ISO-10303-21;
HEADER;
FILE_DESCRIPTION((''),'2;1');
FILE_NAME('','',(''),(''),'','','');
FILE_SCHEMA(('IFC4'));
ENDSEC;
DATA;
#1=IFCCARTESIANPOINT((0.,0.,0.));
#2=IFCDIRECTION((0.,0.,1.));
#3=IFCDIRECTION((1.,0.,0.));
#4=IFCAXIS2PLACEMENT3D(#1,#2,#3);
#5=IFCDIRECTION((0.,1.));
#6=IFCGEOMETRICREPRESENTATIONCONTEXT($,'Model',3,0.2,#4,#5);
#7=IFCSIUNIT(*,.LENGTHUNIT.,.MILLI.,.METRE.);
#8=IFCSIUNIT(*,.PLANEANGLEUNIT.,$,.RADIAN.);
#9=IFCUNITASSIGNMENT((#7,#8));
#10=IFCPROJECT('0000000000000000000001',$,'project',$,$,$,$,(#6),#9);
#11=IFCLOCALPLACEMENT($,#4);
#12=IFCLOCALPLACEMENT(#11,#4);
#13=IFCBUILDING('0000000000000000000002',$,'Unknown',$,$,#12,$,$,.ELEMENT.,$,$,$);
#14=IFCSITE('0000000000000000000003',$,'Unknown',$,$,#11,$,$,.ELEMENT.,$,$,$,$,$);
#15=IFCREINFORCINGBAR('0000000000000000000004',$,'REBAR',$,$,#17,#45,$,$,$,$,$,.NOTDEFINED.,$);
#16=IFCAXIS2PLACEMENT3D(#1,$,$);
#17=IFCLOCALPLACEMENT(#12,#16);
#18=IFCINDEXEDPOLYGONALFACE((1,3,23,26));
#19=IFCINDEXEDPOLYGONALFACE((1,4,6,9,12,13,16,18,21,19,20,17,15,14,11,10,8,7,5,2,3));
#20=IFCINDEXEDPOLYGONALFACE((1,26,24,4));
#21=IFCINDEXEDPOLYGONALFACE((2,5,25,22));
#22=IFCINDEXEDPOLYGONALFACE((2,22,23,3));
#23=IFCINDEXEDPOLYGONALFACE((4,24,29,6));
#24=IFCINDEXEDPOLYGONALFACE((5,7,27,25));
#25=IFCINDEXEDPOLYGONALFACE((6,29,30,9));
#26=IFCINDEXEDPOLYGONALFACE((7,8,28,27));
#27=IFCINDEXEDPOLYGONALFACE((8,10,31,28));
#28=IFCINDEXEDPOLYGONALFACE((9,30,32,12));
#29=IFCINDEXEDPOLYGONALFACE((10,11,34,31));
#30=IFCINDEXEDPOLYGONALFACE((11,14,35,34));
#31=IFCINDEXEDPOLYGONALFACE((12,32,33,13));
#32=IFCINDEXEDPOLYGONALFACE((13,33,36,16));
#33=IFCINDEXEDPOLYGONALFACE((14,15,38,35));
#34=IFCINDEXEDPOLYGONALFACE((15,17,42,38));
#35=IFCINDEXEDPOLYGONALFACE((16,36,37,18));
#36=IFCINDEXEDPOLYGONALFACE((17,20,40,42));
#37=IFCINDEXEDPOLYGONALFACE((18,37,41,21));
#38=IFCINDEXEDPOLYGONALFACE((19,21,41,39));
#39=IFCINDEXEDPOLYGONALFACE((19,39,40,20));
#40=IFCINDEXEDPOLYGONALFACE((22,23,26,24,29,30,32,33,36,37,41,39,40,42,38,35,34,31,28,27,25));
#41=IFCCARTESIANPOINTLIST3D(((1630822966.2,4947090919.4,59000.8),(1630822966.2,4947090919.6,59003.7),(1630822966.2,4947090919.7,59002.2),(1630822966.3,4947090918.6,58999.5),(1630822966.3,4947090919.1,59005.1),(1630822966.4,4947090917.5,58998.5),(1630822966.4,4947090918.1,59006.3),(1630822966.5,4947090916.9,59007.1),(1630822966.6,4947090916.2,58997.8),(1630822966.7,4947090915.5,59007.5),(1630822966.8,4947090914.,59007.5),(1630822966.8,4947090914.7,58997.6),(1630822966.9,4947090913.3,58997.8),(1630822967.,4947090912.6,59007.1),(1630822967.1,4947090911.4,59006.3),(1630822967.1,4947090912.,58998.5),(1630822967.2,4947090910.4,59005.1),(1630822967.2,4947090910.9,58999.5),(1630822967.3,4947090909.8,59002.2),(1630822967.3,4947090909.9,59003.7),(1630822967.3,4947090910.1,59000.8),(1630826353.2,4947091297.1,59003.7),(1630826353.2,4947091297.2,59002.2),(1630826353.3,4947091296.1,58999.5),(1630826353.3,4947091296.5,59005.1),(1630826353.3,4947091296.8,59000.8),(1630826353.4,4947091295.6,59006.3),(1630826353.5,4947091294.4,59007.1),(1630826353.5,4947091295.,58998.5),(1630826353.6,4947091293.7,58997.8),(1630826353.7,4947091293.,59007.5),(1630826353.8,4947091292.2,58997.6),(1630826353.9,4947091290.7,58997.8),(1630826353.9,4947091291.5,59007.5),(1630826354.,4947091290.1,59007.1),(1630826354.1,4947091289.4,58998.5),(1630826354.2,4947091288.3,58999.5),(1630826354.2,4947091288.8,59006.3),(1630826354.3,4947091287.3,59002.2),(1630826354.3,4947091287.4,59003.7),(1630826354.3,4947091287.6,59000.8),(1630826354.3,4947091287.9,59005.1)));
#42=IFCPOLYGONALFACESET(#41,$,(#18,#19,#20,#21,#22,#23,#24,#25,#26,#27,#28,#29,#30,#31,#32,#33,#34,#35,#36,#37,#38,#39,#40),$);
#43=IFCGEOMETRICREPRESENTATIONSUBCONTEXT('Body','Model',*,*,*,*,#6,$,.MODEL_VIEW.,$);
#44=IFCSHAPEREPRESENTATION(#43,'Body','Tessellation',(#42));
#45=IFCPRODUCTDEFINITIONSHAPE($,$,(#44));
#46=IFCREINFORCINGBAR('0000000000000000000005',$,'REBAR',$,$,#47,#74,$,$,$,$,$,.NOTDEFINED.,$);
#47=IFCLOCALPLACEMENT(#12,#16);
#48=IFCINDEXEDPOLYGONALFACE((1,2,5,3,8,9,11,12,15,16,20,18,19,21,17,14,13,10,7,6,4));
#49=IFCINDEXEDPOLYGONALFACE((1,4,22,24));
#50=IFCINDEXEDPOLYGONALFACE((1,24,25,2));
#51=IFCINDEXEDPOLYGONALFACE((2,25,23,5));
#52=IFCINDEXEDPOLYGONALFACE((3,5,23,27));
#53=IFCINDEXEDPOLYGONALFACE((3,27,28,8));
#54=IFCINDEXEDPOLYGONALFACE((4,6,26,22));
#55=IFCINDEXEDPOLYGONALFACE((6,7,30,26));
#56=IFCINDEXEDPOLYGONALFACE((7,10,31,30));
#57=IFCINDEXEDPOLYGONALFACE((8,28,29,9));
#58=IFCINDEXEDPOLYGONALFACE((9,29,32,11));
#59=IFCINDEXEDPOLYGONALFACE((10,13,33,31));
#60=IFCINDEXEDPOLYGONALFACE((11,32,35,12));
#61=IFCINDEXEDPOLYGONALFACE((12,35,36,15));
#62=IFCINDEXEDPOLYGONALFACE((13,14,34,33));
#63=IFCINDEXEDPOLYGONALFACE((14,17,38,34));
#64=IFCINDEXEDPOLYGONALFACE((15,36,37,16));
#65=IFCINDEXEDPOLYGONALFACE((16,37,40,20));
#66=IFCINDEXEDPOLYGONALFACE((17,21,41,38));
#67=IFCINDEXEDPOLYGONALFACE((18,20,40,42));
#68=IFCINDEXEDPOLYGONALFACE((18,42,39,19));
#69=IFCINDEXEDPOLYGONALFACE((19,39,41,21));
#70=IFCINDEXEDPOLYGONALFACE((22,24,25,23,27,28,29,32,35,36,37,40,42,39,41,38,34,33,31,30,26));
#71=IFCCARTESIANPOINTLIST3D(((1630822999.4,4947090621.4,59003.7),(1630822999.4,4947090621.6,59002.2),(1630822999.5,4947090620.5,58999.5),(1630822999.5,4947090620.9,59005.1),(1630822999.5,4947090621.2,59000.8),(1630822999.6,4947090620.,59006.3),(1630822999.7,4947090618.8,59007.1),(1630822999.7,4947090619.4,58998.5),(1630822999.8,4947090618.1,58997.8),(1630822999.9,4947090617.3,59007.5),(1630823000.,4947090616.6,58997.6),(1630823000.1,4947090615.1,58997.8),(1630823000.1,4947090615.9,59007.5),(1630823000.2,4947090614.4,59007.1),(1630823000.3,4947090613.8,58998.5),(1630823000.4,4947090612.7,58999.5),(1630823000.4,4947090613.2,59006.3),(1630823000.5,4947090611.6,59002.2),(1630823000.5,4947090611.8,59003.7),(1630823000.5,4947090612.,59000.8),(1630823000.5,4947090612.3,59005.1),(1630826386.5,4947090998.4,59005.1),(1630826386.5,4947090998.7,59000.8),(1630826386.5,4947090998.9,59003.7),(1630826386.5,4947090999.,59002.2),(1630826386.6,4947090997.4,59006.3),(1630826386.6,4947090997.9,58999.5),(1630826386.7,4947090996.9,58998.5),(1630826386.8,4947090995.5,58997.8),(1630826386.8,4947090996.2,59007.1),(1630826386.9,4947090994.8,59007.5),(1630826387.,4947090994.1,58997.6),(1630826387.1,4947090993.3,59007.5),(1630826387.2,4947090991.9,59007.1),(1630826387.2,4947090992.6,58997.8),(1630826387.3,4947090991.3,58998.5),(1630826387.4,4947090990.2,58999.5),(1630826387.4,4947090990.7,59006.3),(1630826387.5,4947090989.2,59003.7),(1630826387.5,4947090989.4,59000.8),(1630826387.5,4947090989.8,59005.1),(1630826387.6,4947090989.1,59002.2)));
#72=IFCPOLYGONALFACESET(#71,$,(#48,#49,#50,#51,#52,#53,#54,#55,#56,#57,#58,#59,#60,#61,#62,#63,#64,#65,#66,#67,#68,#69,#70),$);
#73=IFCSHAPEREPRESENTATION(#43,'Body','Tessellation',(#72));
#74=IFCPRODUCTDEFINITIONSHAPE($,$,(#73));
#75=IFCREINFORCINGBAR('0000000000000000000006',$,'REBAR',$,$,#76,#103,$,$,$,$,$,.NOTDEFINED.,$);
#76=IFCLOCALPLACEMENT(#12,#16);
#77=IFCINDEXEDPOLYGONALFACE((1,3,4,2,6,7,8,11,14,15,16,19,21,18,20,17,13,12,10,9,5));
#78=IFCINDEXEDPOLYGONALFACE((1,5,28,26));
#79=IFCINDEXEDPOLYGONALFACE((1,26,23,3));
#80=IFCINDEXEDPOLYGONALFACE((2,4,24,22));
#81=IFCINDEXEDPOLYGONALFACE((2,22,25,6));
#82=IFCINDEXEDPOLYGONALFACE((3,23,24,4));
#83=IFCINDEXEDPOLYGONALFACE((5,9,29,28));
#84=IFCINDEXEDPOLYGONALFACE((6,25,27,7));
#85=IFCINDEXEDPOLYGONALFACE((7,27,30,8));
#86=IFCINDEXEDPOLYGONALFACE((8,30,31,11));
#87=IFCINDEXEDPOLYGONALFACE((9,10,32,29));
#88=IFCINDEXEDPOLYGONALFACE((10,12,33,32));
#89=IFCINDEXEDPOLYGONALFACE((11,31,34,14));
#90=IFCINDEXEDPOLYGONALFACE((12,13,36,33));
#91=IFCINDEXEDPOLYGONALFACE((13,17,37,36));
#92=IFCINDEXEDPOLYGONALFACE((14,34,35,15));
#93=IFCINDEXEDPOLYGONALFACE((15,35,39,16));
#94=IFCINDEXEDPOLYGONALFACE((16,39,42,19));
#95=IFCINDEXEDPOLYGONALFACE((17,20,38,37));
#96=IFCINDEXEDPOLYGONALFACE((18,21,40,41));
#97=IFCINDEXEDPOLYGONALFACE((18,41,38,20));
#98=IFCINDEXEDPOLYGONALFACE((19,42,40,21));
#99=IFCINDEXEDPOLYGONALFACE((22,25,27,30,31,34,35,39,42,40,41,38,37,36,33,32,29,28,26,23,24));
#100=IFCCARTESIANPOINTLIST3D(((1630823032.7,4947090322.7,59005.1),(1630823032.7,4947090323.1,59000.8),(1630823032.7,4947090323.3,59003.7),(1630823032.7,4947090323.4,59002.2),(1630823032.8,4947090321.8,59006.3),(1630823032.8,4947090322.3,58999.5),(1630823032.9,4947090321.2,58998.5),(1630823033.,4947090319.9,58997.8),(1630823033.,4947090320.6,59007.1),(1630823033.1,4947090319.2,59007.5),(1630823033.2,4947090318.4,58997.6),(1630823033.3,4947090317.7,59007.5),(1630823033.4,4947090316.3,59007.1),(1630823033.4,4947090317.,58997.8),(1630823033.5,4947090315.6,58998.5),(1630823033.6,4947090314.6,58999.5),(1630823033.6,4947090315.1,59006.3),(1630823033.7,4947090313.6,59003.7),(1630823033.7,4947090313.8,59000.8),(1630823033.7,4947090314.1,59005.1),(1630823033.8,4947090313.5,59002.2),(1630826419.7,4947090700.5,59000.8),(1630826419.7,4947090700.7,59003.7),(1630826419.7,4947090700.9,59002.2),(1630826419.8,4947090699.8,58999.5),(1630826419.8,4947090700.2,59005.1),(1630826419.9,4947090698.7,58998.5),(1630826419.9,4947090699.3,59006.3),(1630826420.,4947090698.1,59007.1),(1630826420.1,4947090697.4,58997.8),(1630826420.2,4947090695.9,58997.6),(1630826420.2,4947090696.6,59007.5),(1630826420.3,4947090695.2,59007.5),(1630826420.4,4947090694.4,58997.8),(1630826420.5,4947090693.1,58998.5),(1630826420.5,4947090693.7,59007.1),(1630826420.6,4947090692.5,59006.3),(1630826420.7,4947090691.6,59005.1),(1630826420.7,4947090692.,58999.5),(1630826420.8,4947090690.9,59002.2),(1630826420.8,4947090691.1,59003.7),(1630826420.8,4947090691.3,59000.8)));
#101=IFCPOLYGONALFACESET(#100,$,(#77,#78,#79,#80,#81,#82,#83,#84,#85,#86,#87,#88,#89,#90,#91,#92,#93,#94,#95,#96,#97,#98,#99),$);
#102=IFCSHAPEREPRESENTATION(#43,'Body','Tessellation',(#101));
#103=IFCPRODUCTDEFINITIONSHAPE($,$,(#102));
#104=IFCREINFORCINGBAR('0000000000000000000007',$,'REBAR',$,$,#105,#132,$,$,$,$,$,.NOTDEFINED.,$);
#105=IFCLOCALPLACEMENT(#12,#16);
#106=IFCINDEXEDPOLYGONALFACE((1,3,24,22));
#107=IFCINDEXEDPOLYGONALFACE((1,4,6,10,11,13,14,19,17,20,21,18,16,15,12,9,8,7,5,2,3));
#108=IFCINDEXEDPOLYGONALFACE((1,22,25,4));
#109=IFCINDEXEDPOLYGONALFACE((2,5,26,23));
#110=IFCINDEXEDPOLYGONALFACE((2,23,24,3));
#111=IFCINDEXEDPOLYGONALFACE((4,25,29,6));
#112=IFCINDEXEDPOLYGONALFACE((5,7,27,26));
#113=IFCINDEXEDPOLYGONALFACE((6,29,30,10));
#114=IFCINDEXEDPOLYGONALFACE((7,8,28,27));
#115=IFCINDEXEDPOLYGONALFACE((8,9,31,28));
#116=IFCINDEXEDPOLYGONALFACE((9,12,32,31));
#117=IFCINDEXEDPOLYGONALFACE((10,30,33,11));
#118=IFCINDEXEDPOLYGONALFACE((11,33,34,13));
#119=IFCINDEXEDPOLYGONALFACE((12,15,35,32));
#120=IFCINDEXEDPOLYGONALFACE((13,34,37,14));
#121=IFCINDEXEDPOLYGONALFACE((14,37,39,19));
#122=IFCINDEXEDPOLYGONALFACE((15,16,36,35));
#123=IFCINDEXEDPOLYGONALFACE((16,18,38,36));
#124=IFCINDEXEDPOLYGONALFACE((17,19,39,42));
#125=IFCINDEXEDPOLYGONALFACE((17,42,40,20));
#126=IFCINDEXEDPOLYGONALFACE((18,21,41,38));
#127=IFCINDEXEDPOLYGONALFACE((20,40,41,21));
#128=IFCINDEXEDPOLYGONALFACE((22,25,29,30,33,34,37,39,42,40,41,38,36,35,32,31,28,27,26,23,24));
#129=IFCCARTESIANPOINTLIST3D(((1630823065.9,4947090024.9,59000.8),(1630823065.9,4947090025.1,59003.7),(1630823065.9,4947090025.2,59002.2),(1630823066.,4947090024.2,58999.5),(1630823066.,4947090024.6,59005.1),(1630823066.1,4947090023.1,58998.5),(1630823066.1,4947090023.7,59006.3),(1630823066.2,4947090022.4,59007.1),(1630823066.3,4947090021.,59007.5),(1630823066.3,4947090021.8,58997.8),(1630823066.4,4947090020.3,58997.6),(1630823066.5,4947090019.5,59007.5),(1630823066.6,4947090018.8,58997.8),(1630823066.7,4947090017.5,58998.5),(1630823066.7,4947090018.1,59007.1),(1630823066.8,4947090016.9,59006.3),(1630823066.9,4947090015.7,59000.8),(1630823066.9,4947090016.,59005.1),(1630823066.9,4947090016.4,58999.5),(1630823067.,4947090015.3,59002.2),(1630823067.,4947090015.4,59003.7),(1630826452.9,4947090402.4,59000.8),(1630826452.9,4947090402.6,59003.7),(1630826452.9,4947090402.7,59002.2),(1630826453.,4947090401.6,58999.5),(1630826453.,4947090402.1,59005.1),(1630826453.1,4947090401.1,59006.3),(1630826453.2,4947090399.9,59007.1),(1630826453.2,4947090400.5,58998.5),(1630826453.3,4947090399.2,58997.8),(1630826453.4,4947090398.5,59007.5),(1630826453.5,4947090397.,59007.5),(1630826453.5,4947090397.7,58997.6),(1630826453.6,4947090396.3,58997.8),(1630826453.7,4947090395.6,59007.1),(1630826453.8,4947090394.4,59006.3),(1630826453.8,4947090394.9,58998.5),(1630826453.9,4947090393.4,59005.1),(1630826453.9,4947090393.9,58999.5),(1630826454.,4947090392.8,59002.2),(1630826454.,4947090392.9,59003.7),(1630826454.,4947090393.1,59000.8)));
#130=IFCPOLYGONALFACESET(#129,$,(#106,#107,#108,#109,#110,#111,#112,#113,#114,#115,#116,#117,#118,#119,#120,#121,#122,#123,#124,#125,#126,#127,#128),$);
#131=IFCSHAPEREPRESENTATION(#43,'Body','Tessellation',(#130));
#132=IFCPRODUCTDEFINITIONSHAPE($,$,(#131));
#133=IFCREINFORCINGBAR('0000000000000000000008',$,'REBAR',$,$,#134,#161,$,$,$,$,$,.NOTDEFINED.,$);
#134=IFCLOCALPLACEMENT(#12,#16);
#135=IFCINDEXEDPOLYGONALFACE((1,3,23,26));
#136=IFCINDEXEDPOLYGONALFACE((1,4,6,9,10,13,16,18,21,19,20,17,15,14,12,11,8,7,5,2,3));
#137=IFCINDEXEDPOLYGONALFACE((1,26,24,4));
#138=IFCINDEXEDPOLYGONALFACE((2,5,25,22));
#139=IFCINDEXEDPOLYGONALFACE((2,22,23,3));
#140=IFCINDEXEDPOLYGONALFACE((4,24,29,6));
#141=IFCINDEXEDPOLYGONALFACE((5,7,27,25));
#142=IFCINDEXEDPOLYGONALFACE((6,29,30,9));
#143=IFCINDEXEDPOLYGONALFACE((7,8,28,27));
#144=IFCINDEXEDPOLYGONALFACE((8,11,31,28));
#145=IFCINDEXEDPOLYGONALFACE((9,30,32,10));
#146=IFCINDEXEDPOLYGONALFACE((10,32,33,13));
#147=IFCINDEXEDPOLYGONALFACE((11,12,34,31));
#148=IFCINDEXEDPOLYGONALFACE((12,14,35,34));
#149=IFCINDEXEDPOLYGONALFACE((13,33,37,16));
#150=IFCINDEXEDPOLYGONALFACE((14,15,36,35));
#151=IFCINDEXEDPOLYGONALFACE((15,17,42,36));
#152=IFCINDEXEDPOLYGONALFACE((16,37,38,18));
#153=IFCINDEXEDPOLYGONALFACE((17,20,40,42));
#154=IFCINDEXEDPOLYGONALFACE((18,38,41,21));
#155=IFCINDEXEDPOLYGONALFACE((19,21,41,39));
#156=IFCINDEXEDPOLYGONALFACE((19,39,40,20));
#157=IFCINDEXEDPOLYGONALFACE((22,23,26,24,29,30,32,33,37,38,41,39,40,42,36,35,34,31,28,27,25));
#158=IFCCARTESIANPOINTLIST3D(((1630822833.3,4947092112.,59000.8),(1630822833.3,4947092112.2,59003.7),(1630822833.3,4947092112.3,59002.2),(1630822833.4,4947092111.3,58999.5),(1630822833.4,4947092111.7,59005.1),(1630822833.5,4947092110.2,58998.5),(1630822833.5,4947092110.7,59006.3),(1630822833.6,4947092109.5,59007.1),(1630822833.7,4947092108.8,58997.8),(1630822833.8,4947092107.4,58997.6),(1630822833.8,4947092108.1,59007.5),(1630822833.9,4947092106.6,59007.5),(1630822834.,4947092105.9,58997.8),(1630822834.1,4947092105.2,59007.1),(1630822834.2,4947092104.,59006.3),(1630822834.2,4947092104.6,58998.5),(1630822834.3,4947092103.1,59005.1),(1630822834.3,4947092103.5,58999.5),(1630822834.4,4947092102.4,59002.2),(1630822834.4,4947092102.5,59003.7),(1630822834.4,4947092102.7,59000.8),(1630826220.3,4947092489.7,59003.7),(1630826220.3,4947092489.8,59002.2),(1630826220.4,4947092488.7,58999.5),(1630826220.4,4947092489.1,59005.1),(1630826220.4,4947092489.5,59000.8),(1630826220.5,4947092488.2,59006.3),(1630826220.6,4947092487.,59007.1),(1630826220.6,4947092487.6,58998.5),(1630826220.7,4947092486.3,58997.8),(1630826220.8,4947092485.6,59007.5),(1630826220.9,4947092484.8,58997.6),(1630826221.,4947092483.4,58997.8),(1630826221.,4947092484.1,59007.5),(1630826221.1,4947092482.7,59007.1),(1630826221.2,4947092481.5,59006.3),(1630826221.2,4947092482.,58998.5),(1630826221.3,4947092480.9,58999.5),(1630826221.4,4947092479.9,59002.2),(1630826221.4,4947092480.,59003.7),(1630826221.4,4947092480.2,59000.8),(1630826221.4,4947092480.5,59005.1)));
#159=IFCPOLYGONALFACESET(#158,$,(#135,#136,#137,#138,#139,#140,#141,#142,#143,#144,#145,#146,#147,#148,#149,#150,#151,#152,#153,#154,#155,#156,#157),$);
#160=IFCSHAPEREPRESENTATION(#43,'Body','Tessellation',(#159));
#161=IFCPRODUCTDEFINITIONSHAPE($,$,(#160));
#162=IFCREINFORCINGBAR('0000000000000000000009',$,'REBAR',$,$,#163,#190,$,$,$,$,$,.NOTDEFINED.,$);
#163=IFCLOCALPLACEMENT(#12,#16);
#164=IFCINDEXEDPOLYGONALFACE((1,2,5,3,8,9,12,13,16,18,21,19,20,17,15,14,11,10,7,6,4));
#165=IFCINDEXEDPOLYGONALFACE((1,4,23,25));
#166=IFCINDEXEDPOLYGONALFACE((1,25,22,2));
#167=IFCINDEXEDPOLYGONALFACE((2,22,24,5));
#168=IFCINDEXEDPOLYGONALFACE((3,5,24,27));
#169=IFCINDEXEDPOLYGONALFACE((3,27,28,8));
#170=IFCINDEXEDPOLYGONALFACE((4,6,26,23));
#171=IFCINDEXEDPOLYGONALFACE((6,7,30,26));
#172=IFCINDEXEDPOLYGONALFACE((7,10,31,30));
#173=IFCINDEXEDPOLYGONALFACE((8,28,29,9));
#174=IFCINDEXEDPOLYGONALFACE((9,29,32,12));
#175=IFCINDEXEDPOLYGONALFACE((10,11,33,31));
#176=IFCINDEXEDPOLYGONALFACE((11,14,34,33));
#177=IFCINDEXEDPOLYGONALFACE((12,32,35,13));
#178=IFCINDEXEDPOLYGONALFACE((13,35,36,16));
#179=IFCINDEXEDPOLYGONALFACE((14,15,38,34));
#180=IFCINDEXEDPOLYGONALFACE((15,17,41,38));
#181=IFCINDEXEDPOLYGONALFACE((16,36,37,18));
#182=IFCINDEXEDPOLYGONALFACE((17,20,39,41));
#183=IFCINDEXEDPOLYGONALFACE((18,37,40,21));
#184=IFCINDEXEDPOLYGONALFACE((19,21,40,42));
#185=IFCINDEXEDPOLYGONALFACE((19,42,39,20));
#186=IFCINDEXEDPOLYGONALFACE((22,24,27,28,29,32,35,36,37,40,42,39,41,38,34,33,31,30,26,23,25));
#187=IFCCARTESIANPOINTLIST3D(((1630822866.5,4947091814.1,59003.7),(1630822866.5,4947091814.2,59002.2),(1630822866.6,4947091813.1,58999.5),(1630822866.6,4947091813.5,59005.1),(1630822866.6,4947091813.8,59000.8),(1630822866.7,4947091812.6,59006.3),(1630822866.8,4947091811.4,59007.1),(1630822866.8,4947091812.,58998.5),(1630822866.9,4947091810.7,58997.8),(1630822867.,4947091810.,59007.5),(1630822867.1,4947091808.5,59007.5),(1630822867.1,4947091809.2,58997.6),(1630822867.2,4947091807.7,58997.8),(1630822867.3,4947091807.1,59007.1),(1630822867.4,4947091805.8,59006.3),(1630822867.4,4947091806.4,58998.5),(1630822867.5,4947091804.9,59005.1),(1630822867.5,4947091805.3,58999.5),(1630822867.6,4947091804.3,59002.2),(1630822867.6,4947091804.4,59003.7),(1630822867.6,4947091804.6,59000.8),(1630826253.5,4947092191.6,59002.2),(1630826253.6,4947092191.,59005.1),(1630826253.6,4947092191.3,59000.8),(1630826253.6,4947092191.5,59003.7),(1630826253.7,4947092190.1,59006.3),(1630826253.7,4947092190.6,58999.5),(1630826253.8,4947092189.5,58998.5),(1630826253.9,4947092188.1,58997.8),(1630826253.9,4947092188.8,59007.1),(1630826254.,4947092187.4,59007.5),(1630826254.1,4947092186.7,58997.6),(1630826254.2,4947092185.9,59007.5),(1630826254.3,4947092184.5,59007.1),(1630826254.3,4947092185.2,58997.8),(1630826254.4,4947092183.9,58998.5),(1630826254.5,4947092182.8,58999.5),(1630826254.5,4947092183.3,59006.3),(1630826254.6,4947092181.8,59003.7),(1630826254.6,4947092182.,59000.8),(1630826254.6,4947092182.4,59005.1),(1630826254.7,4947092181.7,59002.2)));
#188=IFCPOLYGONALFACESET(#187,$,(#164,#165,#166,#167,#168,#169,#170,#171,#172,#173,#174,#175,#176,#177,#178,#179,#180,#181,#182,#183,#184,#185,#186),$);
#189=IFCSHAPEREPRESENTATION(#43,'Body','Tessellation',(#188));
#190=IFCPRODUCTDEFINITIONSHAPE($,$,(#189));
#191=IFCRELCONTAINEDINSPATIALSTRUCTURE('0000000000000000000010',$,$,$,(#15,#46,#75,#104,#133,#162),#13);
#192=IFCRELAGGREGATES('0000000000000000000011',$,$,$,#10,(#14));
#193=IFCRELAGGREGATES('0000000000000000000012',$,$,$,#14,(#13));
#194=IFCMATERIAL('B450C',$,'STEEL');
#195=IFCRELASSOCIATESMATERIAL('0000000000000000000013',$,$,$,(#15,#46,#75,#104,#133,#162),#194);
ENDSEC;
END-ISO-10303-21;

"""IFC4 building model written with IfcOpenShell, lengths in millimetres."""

from ifc_helpers import new_model, entity, si_unit, direction, frame, origin_with_axes, place, context, subcontext, project, spatial, material, element, save


model = new_model("IFC4")

# Units and contexts
model_context = context("Model", 3, precision=0.2, world=origin_with_axes(), true_north=direction((0.0, 1.0)))
body_context = subcontext(model_context, "Body", "Model", "MODEL_VIEW")
ifc_project = project(units=[si_unit("LENGTHUNIT", "METRE", prefix="MILLI"), si_unit("PLANEANGLEUNIT", "RADIAN")], contexts=[model_context])

# Site, building
site_placement = place(None, origin_with_axes())
site = spatial("IfcSite", under=ifc_project, at=site_placement, Name="Unknown", CompositionType="ELEMENT")
building_placement = place(site_placement, origin_with_axes())
building = spatial("IfcBuilding", under=site, at=building_placement, Name="Unknown", CompositionType="ELEMENT")

# Reinforcing bars
ifc_material = material(Name="B450C", Category="STEEL")
reinforcing_bar_1_placement = place(building_placement, frame((1630826353.8, 4947091292.2, 59002.6), z_axis=(0.000031, -0.000282, -1.0), x_axis=(-0.993847, -0.110757, 0.0)))
element("IfcReinforcingBar", 1, at=reinforcing_bar_1_placement, inside=building, material=ifc_material, Name="REBAR", PredefinedType="NOTDEFINED", context=body_context, shape_type="AdvancedSweptSolid", body=[
    entity("IfcSweptDiskSolid", entity("IfcIndexedPolyCurve", entity("IfcCartesianPointList3D", [[0.0, 0.0, 0.0], [3408.0, 0.0, 0.0]]), [entity("IfcLineIndex", [1, 2])]), 5.0),
])
for number, where, z_axis, x_axis, name in (
    (2, (1630826387.0, 4947090994.1, 59002.6), (0.000031, -0.000282, -1.0), (-0.993847, -0.110757, 0.0), "REBAR"),
    (3, (1630826420.2, 4947090695.9, 59002.6), (0.000031, -0.000282, -1.0), (-0.993847, -0.110757, 0.0), "REBAR"),
    (4, (1630826453.5, 4947090397.7, 59002.6), (0.000031, -0.000282, -1.0), (-0.993847, -0.110757, 0.0), "REBAR"),
):
    element("IfcReinforcingBar", number, at=place(building_placement, frame(where, z_axis=z_axis, x_axis=x_axis)), inside=building, material=ifc_material, Name=name, PredefinedType="NOTDEFINED", context=body_context, shape_type="AdvancedSweptSolid", body=[
        entity("IfcSweptDiskSolid", entity("IfcIndexedPolyCurve", entity("IfcCartesianPointList3D", [[0.0, 0.0, 0.0], [3408.0, 0.0, 0.0]]), [entity("IfcLineIndex", [1, 2])]), 5.0),
    ])
reinforcing_bar_2_placement = place(building_placement, frame((1630826220.9, 4947092484.8, 59002.6), z_axis=(0.000031, -0.000282, -1.0), x_axis=(-0.993847, -0.110757, 0.0)))
element("IfcReinforcingBar", 5, at=reinforcing_bar_2_placement, inside=building, material=ifc_material, Name="REBAR", PredefinedType="NOTDEFINED", context=body_context, shape_type="AdvancedSweptSolid", body=[
    entity("IfcSweptDiskSolid", entity("IfcIndexedPolyCurve", entity("IfcCartesianPointList3D", [[0.0, 0.0, 0.0], [3408.0, 0.0, 0.0]]), [entity("IfcLineIndex", [1, 2])]), 5.0),
])
for number, where, z_axis, x_axis, name in (
    (6, (1630826254.1, 4947092186.7, 59002.6), (0.000031, -0.000282, -1.0), (-0.993847, -0.110757, 0.0), "REBAR"),
):
    element("IfcReinforcingBar", number, at=place(building_placement, frame(where, z_axis=z_axis, x_axis=x_axis)), inside=building, material=ifc_material, Name=name, PredefinedType="NOTDEFINED", context=body_context, shape_type="AdvancedSweptSolid", body=[
        entity("IfcSweptDiskSolid", entity("IfcIndexedPolyCurve", entity("IfcCartesianPointList3D", [[0.0, 0.0, 0.0], [3408.0, 0.0, 0.0]]), [entity("IfcLineIndex", [1, 2])]), 5.0),
    ])

save(model, "model.ifc")
